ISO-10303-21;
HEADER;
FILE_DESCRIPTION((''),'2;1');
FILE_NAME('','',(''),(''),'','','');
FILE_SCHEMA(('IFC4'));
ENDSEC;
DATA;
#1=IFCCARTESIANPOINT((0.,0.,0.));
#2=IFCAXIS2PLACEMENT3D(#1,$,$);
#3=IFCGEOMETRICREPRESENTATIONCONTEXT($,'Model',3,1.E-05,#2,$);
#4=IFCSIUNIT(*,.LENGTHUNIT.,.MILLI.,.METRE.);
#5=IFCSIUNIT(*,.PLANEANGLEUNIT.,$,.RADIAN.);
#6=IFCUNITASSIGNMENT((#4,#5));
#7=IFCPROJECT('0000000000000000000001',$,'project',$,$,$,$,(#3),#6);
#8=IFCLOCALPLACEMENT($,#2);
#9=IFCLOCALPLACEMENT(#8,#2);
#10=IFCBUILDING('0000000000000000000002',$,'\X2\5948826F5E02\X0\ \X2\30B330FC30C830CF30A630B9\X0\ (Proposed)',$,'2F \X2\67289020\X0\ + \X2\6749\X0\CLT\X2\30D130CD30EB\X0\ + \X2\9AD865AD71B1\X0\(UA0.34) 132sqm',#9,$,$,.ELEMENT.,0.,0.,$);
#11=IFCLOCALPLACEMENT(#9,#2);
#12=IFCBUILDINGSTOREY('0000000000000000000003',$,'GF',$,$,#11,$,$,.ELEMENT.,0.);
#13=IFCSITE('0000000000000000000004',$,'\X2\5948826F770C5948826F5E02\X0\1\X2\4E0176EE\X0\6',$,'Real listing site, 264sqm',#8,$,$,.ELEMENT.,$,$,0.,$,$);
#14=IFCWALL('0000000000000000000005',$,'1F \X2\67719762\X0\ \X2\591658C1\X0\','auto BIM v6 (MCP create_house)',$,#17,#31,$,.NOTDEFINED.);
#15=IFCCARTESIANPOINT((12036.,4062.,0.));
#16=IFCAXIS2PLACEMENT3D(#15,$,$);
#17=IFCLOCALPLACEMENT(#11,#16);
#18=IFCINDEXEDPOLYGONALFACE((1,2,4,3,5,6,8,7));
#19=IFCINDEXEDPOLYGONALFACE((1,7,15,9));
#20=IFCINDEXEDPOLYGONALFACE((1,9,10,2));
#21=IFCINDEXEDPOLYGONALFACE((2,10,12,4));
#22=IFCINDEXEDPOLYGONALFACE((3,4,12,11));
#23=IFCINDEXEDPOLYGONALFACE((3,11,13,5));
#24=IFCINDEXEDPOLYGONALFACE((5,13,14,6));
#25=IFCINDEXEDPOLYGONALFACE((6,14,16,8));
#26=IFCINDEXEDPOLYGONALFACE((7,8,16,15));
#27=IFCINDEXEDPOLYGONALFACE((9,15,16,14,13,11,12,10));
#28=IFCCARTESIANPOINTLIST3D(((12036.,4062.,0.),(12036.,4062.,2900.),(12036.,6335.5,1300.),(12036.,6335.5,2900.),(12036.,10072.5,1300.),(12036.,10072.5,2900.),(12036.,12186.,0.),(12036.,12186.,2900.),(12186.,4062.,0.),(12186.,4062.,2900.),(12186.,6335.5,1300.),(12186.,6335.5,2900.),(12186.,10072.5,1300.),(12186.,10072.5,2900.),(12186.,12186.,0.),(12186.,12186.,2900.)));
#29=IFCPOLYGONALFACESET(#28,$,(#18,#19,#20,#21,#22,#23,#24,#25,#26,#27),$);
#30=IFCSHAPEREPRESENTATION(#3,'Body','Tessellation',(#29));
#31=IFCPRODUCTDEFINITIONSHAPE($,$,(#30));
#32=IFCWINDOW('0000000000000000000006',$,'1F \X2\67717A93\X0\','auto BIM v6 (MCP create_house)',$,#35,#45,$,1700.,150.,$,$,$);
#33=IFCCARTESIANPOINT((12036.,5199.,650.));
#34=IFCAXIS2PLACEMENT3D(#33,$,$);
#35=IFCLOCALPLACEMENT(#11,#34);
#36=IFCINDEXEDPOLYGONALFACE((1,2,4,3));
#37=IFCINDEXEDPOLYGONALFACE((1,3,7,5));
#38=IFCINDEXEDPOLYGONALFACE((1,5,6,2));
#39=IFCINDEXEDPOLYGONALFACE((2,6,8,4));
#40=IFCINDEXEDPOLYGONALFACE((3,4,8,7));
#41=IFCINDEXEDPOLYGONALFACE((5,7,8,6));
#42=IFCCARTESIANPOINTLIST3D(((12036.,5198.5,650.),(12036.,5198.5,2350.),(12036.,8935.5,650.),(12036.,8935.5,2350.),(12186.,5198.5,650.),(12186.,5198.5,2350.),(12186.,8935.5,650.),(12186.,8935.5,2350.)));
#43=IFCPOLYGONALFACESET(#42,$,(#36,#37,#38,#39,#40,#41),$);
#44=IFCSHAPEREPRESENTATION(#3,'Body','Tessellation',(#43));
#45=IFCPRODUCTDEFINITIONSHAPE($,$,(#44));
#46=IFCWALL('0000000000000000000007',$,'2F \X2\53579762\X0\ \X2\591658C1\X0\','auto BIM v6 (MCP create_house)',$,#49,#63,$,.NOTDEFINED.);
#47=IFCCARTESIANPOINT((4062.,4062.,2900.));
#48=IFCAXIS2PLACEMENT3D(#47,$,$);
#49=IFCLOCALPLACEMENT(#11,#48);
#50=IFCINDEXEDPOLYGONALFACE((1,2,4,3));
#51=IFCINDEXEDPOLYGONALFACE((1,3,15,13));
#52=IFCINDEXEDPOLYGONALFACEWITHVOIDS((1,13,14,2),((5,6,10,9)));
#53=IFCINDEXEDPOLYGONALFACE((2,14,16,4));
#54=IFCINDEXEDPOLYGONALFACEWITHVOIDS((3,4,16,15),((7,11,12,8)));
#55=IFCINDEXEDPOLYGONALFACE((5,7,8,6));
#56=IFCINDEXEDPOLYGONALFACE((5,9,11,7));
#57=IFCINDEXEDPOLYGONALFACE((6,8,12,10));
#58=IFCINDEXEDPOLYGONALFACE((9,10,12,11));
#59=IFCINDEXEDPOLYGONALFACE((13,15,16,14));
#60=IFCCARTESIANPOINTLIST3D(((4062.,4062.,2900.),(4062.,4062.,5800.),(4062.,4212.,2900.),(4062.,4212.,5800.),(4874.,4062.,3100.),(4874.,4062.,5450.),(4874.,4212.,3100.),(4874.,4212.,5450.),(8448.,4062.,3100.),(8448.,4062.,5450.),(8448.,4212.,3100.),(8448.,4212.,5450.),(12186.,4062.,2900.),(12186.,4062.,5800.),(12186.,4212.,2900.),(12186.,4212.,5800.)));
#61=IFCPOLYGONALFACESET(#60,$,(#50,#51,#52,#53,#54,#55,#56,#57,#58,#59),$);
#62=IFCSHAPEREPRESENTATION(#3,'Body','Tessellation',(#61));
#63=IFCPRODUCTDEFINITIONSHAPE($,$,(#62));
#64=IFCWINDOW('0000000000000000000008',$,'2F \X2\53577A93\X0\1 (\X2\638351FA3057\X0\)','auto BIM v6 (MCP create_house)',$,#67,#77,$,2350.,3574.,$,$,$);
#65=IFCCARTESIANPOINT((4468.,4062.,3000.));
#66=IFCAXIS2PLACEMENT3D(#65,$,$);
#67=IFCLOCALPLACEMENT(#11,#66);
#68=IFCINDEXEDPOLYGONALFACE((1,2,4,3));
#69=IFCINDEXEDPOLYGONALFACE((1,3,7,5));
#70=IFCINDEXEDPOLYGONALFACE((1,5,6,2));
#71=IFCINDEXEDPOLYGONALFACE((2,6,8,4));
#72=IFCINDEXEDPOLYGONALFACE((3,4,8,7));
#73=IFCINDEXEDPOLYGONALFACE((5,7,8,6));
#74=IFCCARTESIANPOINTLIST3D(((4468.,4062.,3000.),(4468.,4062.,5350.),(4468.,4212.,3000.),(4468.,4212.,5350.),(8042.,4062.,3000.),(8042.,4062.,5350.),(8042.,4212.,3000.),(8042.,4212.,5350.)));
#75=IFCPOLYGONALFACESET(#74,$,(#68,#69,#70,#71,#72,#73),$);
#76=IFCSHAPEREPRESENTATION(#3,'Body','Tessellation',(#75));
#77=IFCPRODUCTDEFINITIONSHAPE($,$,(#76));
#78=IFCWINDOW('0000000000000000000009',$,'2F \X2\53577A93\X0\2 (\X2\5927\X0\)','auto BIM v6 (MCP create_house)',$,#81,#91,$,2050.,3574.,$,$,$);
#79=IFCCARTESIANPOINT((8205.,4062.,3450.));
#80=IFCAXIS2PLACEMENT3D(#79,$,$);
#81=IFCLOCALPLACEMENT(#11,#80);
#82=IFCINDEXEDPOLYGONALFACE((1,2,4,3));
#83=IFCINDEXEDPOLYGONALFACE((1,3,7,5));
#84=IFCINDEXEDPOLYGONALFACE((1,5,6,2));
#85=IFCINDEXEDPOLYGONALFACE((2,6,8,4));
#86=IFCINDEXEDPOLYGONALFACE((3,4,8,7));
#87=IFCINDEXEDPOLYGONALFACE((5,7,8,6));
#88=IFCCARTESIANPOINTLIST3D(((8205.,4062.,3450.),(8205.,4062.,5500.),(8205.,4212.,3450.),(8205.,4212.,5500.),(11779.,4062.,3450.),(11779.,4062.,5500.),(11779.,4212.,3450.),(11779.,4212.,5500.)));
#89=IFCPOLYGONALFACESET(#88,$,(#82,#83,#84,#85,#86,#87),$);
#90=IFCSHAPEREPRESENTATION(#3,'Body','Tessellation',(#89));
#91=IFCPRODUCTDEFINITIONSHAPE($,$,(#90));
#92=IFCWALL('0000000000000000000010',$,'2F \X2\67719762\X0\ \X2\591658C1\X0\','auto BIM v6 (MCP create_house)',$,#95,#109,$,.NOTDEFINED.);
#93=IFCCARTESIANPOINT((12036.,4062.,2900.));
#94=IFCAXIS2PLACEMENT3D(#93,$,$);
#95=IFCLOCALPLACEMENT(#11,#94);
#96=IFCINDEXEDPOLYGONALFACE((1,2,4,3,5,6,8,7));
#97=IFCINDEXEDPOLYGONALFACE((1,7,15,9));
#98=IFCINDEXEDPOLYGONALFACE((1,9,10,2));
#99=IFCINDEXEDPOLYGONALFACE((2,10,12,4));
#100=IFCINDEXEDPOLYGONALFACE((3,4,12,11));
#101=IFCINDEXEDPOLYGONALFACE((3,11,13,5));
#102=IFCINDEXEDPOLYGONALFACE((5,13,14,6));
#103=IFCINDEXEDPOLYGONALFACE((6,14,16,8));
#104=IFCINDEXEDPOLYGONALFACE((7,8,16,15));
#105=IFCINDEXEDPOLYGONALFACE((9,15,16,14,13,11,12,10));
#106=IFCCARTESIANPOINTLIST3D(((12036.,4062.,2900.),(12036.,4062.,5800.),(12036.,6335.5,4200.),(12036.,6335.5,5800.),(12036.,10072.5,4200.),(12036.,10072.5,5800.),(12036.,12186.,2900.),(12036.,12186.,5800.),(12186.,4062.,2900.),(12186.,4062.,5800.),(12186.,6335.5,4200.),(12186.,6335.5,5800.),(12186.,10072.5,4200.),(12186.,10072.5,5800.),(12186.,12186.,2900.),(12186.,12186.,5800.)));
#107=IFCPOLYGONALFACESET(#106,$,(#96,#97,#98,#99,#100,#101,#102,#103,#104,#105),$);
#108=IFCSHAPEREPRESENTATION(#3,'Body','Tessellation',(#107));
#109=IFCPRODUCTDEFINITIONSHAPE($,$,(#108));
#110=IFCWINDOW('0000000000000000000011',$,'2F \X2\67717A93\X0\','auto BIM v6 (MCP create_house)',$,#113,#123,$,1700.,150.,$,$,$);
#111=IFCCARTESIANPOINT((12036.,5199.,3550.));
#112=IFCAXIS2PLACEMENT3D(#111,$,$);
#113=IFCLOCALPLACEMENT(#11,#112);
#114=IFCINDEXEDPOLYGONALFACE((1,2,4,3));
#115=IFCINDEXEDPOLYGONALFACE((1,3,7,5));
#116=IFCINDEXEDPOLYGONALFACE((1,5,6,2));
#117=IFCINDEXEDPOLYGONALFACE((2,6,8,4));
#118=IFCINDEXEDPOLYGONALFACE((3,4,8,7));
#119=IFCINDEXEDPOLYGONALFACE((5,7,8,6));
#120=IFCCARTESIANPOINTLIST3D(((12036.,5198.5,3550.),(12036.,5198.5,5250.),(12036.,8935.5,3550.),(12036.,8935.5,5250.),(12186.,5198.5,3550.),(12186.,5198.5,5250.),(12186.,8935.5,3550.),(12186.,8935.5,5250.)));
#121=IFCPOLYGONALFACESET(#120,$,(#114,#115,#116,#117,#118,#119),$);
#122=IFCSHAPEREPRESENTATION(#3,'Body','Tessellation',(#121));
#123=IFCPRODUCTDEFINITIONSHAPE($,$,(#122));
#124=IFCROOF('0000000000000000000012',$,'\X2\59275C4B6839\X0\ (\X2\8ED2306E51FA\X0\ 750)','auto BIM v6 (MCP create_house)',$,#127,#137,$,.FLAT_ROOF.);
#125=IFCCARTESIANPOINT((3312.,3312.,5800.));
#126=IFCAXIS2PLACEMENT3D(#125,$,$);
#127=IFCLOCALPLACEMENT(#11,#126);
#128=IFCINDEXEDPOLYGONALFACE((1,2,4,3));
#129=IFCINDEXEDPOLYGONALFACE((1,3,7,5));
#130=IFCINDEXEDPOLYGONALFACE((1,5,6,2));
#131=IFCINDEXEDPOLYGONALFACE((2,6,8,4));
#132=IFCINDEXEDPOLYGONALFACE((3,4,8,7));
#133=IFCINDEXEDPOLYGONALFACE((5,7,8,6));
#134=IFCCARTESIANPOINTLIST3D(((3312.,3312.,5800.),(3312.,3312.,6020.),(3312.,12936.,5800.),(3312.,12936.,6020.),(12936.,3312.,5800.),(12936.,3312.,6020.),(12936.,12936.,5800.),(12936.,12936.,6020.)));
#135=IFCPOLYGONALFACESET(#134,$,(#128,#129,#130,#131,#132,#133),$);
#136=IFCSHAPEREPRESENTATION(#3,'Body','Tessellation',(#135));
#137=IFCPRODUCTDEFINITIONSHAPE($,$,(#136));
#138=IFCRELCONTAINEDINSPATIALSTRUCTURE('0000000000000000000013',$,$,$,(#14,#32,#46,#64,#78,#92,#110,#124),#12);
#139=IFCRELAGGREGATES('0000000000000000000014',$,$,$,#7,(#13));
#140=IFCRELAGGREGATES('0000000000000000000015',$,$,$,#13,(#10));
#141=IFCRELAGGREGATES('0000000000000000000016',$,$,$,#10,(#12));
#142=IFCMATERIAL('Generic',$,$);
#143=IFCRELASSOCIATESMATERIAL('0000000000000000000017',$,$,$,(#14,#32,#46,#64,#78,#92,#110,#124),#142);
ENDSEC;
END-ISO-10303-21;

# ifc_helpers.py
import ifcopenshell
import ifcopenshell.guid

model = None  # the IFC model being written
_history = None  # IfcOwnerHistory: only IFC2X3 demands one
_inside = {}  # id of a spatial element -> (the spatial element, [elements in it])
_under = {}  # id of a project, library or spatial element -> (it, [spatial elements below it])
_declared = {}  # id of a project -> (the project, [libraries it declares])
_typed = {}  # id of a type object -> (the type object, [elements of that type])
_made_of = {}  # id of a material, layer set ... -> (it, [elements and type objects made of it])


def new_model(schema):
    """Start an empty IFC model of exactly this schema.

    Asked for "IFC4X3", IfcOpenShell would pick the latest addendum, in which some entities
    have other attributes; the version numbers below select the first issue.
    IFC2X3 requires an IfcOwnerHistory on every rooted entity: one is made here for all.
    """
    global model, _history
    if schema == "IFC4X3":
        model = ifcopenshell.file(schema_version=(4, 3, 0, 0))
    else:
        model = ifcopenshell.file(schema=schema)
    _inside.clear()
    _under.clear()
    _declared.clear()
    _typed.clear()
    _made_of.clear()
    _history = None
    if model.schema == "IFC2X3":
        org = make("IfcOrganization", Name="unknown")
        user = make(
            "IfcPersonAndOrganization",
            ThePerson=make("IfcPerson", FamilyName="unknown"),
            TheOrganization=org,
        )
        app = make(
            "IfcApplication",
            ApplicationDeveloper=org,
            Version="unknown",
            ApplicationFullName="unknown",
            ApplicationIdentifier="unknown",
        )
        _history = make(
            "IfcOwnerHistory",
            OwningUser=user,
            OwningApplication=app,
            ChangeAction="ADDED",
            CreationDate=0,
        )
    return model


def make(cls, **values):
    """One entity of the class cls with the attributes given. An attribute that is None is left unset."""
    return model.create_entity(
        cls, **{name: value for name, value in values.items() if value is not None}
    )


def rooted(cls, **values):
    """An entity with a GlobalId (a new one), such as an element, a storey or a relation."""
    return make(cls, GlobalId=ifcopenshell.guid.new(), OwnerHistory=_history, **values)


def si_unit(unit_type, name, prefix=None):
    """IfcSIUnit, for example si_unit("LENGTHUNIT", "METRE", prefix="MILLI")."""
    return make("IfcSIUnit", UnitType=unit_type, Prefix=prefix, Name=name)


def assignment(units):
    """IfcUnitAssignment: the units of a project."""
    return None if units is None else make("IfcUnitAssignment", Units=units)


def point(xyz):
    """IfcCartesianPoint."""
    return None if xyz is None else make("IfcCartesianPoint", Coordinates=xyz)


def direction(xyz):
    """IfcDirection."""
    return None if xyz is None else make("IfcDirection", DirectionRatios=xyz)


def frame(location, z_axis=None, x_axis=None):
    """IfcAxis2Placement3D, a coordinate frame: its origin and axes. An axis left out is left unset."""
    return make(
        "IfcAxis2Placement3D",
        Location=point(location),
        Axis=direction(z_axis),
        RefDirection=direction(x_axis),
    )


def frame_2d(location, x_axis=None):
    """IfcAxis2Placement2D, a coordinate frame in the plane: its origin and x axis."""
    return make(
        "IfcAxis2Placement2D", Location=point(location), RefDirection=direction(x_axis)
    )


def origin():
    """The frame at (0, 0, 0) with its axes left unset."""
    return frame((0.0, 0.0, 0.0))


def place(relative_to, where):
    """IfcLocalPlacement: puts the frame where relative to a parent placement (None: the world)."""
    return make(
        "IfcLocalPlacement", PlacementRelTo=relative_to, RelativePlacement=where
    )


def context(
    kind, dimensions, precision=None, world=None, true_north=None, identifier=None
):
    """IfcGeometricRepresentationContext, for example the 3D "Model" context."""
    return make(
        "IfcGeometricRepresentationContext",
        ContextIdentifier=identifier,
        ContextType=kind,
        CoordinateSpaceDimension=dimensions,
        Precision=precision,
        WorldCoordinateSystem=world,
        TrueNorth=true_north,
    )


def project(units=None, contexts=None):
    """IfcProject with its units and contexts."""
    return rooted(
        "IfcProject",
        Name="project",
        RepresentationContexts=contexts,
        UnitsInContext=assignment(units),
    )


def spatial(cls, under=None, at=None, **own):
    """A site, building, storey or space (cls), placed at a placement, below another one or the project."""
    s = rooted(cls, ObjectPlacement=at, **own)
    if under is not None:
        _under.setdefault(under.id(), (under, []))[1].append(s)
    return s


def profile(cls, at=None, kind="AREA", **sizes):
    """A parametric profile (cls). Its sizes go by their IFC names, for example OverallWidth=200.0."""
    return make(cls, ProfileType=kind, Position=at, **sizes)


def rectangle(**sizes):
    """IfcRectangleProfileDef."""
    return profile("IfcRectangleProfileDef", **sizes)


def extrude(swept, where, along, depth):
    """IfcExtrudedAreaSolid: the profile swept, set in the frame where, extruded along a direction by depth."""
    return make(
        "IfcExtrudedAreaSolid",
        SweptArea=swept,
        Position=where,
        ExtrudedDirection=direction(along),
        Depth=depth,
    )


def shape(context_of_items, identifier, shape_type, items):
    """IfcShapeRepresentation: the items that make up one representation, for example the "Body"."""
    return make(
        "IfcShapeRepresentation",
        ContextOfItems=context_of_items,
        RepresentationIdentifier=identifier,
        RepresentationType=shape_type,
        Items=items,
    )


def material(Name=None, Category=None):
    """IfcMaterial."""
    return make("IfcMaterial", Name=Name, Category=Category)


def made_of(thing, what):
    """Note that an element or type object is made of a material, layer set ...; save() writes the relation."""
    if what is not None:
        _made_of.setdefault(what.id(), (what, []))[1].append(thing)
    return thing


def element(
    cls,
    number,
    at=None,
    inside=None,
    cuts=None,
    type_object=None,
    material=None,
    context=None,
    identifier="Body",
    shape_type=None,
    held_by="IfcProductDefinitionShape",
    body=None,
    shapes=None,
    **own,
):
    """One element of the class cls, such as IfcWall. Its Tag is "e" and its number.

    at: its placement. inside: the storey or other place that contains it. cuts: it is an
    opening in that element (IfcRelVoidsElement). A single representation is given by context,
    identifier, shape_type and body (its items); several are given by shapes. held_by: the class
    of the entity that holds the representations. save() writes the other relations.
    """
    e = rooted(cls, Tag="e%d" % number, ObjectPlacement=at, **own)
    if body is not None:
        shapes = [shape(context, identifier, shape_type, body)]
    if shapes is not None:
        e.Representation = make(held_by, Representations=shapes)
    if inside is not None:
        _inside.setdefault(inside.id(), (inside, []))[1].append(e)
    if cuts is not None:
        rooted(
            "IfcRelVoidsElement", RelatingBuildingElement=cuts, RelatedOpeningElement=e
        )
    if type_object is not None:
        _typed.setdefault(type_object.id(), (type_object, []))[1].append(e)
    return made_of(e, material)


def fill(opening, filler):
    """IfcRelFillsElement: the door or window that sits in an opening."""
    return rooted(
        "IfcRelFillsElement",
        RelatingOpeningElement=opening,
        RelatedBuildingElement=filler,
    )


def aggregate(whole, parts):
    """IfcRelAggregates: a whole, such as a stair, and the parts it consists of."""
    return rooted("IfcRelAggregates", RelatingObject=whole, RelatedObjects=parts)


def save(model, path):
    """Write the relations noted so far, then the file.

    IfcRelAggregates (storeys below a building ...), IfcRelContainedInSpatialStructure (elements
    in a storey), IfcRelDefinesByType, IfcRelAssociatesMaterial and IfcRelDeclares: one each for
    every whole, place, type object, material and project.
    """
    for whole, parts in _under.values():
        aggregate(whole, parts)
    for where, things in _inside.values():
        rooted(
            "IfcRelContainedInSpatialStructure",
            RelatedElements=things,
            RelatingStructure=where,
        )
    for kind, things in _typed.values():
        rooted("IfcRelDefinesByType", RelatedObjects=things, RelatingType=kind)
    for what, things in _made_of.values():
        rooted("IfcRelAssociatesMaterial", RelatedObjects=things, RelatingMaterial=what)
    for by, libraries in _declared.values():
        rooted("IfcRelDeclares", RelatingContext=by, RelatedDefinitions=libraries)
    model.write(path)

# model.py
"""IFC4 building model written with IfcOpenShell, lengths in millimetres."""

from ifc_helpers import new_model, si_unit, frame, frame_2d, origin, place, context, project, spatial, rectangle, extrude, material, element, fill, save


model = new_model("IFC4")

# Units and contexts
model_context = context("Model", 3, precision=1e-05, world=origin())
ifc_project = project(units=[si_unit("LENGTHUNIT", "METRE", prefix="MILLI"), si_unit("PLANEANGLEUNIT", "RADIAN")], contexts=[model_context])

# Site, building, storey
site_placement = place(None, origin())
site = spatial("IfcSite", under=ifc_project, at=site_placement, Name="奈良県奈良市1丁目6", ObjectType="Real listing site, 264sqm", CompositionType="ELEMENT", RefElevation=0.0)
building_placement = place(site_placement, origin())
building = spatial("IfcBuilding", under=site, at=building_placement, Name="奈良市 コートハウス (Proposed)", ObjectType="2F 木造 + 杉CLTパネル + 高断熱(UA0.34) 132sqm", CompositionType="ELEMENT", ElevationOfRefHeight=0.0, ElevationOfTerrain=0.0)
storey_placement = place(building_placement, origin())
storey = spatial("IfcBuildingStorey", under=building, at=storey_placement, Name="GF", CompositionType="ELEMENT", Elevation=0.0)

# Shared definitions
ifc_material = material(Name="Generic")

# Wall, opening, window
wall_1_placement = place(storey_placement, frame((12036.0, 4062.0, 0.0)))
wall_1 = element("IfcWall", 1, at=wall_1_placement, inside=storey, material=ifc_material, Name="1F 東面 外壁", Description="auto BIM v6 (MCP create_house)", PredefinedType="NOTDEFINED", context=model_context, shape_type="SweptSolid", body=[
    extrude(rectangle(XDim=150.0, YDim=8124.0, at=frame_2d((75.0, 4062.0))), frame((12036.0, 4062.0, 0.0)), (0.0, 0.0, 1.0), 2900.0),
])
opening_1_placement = place(storey_placement, frame((12036.0, 5199.0, 650.0)))
opening_1 = element("IfcOpeningElement", 2, at=opening_1_placement, cuts=wall_1, PredefinedType="NOTDEFINED", context=model_context, shape_type="SweptSolid", body=[
    extrude(rectangle(XDim=150.0, YDim=3737.0, at=frame_2d((75.0, 1868.0))), frame((12036.0, 5199.0, 650.0)), (0.0, 0.0, 1.0), 1700.0),
])
window_1_placement = place(storey_placement, frame((12036.0, 5199.0, 650.0)))
window_1 = element("IfcWindow", 3, at=window_1_placement, inside=storey, material=ifc_material, Name="1F 東窓", Description="auto BIM v6 (MCP create_house)", OverallHeight=1700.0, OverallWidth=150.0, context=model_context, shape_type="SweptSolid", body=[
    extrude(rectangle(XDim=150.0, YDim=3737.0, at=frame_2d((75.0, 1868.0))), frame((12036.0, 5199.0, 650.0)), (0.0, 0.0, 1.0), 1700.0),
])
fill(opening_1, window_1)

# Wall, openings, windows
wall_2_placement = place(storey_placement, frame((4062.0, 4062.0, 2900.0)))
wall_2 = element("IfcWall", 4, at=wall_2_placement, inside=storey, material=ifc_material, Name="2F 南面 外壁", Description="auto BIM v6 (MCP create_house)", PredefinedType="NOTDEFINED", context=model_context, shape_type="SweptSolid", body=[
    extrude(rectangle(XDim=8124.0, YDim=150.0, at=frame_2d((4062.0, 75.0))), frame((4062.0, 4062.0, 2900.0)), (0.0, 0.0, 1.0), 2900.0),
])
opening_2_placement = place(storey_placement, frame((4468.0, 4062.0, 3000.0)))
opening_2 = element("IfcOpeningElement", 5, at=opening_2_placement, cuts=wall_2, PredefinedType="NOTDEFINED", context=model_context, shape_type="SweptSolid", body=[
    extrude(rectangle(XDim=3574.0, YDim=150.0, at=frame_2d((1787.0, 75.0))), frame((4468.0, 4062.0, 3000.0)), (0.0, 0.0, 1.0), 2350.0),
])
opening_3_placement = place(storey_placement, frame((8205.0, 4062.0, 3450.0)))
opening_3 = element("IfcOpeningElement", 6, at=opening_3_placement, cuts=wall_2, PredefinedType="NOTDEFINED", context=model_context, shape_type="SweptSolid", body=[
    extrude(rectangle(XDim=3574.0, YDim=150.0, at=frame_2d((1787.0, 75.0))), frame((8205.0, 4062.0, 3450.0)), (0.0, 0.0, 1.0), 2050.0),
])
window_2_placement = place(storey_placement, frame((4468.0, 4062.0, 3000.0)))
window_2 = element("IfcWindow", 7, at=window_2_placement, inside=storey, material=ifc_material, Name="2F 南窓1 (掃出し)", Description="auto BIM v6 (MCP create_house)", OverallHeight=2350.0, OverallWidth=3574.0, context=model_context, shape_type="SweptSolid", body=[
    extrude(rectangle(XDim=3574.0, YDim=150.0, at=frame_2d((1787.0, 75.0))), frame((4468.0, 4062.0, 3000.0)), (0.0, 0.0, 1.0), 2350.0),
])
fill(opening_2, window_2)
window_3_placement = place(storey_placement, frame((8205.0, 4062.0, 3450.0)))
window_3 = element("IfcWindow", 8, at=window_3_placement, inside=storey, material=ifc_material, Name="2F 南窓2 (大)", Description="auto BIM v6 (MCP create_house)", OverallHeight=2050.0, OverallWidth=3574.0, context=model_context, shape_type="SweptSolid", body=[
    extrude(rectangle(XDim=3574.0, YDim=150.0, at=frame_2d((1787.0, 75.0))), frame((8205.0, 4062.0, 3450.0)), (0.0, 0.0, 1.0), 2050.0),
])
fill(opening_3, window_3)

# Wall, opening, window
wall_3_placement = place(storey_placement, frame((12036.0, 4062.0, 2900.0)))
wall_3 = element("IfcWall", 9, at=wall_3_placement, inside=storey, material=ifc_material, Name="2F 東面 外壁", Description="auto BIM v6 (MCP create_house)", PredefinedType="NOTDEFINED", context=model_context, shape_type="SweptSolid", body=[
    extrude(rectangle(XDim=150.0, YDim=8124.0, at=frame_2d((75.0, 4062.0))), frame((12036.0, 4062.0, 2900.0)), (0.0, 0.0, 1.0), 2900.0),
])
opening_4_placement = place(storey_placement, frame((12036.0, 5199.0, 3550.0)))
opening_4 = element("IfcOpeningElement", 10, at=opening_4_placement, cuts=wall_3, PredefinedType="NOTDEFINED", context=model_context, shape_type="SweptSolid", body=[
    extrude(rectangle(XDim=150.0, YDim=3737.0, at=frame_2d((75.0, 1868.0))), frame((12036.0, 5199.0, 3550.0)), (0.0, 0.0, 1.0), 1700.0),
])
window_4_placement = place(storey_placement, frame((12036.0, 5199.0, 3550.0)))
window_4 = element("IfcWindow", 11, at=window_4_placement, inside=storey, material=ifc_material, Name="2F 東窓", Description="auto BIM v6 (MCP create_house)", OverallHeight=1700.0, OverallWidth=150.0, context=model_context, shape_type="SweptSolid", body=[
    extrude(rectangle(XDim=150.0, YDim=3737.0, at=frame_2d((75.0, 1868.0))), frame((12036.0, 5199.0, 3550.0)), (0.0, 0.0, 1.0), 1700.0),
])
fill(opening_4, window_4)

# Roof
roof_placement = place(storey_placement, frame((3312.0, 3312.0, 5800.0)))
element("IfcRoof", 12, at=roof_placement, inside=storey, material=ifc_material, Name="大屋根 (軒の出 750)", Description="auto BIM v6 (MCP create_house)", PredefinedType="FLAT_ROOF", context=model_context, shape_type="SweptSolid", body=[
    extrude(rectangle(XDim=9624.0, YDim=9624.0, at=frame_2d((4812.0, 4812.0))), frame((3312.0, 3312.0, 5800.0)), (0.0, 0.0, 1.0), 220.0),
])

save(model, "model.ifc")
